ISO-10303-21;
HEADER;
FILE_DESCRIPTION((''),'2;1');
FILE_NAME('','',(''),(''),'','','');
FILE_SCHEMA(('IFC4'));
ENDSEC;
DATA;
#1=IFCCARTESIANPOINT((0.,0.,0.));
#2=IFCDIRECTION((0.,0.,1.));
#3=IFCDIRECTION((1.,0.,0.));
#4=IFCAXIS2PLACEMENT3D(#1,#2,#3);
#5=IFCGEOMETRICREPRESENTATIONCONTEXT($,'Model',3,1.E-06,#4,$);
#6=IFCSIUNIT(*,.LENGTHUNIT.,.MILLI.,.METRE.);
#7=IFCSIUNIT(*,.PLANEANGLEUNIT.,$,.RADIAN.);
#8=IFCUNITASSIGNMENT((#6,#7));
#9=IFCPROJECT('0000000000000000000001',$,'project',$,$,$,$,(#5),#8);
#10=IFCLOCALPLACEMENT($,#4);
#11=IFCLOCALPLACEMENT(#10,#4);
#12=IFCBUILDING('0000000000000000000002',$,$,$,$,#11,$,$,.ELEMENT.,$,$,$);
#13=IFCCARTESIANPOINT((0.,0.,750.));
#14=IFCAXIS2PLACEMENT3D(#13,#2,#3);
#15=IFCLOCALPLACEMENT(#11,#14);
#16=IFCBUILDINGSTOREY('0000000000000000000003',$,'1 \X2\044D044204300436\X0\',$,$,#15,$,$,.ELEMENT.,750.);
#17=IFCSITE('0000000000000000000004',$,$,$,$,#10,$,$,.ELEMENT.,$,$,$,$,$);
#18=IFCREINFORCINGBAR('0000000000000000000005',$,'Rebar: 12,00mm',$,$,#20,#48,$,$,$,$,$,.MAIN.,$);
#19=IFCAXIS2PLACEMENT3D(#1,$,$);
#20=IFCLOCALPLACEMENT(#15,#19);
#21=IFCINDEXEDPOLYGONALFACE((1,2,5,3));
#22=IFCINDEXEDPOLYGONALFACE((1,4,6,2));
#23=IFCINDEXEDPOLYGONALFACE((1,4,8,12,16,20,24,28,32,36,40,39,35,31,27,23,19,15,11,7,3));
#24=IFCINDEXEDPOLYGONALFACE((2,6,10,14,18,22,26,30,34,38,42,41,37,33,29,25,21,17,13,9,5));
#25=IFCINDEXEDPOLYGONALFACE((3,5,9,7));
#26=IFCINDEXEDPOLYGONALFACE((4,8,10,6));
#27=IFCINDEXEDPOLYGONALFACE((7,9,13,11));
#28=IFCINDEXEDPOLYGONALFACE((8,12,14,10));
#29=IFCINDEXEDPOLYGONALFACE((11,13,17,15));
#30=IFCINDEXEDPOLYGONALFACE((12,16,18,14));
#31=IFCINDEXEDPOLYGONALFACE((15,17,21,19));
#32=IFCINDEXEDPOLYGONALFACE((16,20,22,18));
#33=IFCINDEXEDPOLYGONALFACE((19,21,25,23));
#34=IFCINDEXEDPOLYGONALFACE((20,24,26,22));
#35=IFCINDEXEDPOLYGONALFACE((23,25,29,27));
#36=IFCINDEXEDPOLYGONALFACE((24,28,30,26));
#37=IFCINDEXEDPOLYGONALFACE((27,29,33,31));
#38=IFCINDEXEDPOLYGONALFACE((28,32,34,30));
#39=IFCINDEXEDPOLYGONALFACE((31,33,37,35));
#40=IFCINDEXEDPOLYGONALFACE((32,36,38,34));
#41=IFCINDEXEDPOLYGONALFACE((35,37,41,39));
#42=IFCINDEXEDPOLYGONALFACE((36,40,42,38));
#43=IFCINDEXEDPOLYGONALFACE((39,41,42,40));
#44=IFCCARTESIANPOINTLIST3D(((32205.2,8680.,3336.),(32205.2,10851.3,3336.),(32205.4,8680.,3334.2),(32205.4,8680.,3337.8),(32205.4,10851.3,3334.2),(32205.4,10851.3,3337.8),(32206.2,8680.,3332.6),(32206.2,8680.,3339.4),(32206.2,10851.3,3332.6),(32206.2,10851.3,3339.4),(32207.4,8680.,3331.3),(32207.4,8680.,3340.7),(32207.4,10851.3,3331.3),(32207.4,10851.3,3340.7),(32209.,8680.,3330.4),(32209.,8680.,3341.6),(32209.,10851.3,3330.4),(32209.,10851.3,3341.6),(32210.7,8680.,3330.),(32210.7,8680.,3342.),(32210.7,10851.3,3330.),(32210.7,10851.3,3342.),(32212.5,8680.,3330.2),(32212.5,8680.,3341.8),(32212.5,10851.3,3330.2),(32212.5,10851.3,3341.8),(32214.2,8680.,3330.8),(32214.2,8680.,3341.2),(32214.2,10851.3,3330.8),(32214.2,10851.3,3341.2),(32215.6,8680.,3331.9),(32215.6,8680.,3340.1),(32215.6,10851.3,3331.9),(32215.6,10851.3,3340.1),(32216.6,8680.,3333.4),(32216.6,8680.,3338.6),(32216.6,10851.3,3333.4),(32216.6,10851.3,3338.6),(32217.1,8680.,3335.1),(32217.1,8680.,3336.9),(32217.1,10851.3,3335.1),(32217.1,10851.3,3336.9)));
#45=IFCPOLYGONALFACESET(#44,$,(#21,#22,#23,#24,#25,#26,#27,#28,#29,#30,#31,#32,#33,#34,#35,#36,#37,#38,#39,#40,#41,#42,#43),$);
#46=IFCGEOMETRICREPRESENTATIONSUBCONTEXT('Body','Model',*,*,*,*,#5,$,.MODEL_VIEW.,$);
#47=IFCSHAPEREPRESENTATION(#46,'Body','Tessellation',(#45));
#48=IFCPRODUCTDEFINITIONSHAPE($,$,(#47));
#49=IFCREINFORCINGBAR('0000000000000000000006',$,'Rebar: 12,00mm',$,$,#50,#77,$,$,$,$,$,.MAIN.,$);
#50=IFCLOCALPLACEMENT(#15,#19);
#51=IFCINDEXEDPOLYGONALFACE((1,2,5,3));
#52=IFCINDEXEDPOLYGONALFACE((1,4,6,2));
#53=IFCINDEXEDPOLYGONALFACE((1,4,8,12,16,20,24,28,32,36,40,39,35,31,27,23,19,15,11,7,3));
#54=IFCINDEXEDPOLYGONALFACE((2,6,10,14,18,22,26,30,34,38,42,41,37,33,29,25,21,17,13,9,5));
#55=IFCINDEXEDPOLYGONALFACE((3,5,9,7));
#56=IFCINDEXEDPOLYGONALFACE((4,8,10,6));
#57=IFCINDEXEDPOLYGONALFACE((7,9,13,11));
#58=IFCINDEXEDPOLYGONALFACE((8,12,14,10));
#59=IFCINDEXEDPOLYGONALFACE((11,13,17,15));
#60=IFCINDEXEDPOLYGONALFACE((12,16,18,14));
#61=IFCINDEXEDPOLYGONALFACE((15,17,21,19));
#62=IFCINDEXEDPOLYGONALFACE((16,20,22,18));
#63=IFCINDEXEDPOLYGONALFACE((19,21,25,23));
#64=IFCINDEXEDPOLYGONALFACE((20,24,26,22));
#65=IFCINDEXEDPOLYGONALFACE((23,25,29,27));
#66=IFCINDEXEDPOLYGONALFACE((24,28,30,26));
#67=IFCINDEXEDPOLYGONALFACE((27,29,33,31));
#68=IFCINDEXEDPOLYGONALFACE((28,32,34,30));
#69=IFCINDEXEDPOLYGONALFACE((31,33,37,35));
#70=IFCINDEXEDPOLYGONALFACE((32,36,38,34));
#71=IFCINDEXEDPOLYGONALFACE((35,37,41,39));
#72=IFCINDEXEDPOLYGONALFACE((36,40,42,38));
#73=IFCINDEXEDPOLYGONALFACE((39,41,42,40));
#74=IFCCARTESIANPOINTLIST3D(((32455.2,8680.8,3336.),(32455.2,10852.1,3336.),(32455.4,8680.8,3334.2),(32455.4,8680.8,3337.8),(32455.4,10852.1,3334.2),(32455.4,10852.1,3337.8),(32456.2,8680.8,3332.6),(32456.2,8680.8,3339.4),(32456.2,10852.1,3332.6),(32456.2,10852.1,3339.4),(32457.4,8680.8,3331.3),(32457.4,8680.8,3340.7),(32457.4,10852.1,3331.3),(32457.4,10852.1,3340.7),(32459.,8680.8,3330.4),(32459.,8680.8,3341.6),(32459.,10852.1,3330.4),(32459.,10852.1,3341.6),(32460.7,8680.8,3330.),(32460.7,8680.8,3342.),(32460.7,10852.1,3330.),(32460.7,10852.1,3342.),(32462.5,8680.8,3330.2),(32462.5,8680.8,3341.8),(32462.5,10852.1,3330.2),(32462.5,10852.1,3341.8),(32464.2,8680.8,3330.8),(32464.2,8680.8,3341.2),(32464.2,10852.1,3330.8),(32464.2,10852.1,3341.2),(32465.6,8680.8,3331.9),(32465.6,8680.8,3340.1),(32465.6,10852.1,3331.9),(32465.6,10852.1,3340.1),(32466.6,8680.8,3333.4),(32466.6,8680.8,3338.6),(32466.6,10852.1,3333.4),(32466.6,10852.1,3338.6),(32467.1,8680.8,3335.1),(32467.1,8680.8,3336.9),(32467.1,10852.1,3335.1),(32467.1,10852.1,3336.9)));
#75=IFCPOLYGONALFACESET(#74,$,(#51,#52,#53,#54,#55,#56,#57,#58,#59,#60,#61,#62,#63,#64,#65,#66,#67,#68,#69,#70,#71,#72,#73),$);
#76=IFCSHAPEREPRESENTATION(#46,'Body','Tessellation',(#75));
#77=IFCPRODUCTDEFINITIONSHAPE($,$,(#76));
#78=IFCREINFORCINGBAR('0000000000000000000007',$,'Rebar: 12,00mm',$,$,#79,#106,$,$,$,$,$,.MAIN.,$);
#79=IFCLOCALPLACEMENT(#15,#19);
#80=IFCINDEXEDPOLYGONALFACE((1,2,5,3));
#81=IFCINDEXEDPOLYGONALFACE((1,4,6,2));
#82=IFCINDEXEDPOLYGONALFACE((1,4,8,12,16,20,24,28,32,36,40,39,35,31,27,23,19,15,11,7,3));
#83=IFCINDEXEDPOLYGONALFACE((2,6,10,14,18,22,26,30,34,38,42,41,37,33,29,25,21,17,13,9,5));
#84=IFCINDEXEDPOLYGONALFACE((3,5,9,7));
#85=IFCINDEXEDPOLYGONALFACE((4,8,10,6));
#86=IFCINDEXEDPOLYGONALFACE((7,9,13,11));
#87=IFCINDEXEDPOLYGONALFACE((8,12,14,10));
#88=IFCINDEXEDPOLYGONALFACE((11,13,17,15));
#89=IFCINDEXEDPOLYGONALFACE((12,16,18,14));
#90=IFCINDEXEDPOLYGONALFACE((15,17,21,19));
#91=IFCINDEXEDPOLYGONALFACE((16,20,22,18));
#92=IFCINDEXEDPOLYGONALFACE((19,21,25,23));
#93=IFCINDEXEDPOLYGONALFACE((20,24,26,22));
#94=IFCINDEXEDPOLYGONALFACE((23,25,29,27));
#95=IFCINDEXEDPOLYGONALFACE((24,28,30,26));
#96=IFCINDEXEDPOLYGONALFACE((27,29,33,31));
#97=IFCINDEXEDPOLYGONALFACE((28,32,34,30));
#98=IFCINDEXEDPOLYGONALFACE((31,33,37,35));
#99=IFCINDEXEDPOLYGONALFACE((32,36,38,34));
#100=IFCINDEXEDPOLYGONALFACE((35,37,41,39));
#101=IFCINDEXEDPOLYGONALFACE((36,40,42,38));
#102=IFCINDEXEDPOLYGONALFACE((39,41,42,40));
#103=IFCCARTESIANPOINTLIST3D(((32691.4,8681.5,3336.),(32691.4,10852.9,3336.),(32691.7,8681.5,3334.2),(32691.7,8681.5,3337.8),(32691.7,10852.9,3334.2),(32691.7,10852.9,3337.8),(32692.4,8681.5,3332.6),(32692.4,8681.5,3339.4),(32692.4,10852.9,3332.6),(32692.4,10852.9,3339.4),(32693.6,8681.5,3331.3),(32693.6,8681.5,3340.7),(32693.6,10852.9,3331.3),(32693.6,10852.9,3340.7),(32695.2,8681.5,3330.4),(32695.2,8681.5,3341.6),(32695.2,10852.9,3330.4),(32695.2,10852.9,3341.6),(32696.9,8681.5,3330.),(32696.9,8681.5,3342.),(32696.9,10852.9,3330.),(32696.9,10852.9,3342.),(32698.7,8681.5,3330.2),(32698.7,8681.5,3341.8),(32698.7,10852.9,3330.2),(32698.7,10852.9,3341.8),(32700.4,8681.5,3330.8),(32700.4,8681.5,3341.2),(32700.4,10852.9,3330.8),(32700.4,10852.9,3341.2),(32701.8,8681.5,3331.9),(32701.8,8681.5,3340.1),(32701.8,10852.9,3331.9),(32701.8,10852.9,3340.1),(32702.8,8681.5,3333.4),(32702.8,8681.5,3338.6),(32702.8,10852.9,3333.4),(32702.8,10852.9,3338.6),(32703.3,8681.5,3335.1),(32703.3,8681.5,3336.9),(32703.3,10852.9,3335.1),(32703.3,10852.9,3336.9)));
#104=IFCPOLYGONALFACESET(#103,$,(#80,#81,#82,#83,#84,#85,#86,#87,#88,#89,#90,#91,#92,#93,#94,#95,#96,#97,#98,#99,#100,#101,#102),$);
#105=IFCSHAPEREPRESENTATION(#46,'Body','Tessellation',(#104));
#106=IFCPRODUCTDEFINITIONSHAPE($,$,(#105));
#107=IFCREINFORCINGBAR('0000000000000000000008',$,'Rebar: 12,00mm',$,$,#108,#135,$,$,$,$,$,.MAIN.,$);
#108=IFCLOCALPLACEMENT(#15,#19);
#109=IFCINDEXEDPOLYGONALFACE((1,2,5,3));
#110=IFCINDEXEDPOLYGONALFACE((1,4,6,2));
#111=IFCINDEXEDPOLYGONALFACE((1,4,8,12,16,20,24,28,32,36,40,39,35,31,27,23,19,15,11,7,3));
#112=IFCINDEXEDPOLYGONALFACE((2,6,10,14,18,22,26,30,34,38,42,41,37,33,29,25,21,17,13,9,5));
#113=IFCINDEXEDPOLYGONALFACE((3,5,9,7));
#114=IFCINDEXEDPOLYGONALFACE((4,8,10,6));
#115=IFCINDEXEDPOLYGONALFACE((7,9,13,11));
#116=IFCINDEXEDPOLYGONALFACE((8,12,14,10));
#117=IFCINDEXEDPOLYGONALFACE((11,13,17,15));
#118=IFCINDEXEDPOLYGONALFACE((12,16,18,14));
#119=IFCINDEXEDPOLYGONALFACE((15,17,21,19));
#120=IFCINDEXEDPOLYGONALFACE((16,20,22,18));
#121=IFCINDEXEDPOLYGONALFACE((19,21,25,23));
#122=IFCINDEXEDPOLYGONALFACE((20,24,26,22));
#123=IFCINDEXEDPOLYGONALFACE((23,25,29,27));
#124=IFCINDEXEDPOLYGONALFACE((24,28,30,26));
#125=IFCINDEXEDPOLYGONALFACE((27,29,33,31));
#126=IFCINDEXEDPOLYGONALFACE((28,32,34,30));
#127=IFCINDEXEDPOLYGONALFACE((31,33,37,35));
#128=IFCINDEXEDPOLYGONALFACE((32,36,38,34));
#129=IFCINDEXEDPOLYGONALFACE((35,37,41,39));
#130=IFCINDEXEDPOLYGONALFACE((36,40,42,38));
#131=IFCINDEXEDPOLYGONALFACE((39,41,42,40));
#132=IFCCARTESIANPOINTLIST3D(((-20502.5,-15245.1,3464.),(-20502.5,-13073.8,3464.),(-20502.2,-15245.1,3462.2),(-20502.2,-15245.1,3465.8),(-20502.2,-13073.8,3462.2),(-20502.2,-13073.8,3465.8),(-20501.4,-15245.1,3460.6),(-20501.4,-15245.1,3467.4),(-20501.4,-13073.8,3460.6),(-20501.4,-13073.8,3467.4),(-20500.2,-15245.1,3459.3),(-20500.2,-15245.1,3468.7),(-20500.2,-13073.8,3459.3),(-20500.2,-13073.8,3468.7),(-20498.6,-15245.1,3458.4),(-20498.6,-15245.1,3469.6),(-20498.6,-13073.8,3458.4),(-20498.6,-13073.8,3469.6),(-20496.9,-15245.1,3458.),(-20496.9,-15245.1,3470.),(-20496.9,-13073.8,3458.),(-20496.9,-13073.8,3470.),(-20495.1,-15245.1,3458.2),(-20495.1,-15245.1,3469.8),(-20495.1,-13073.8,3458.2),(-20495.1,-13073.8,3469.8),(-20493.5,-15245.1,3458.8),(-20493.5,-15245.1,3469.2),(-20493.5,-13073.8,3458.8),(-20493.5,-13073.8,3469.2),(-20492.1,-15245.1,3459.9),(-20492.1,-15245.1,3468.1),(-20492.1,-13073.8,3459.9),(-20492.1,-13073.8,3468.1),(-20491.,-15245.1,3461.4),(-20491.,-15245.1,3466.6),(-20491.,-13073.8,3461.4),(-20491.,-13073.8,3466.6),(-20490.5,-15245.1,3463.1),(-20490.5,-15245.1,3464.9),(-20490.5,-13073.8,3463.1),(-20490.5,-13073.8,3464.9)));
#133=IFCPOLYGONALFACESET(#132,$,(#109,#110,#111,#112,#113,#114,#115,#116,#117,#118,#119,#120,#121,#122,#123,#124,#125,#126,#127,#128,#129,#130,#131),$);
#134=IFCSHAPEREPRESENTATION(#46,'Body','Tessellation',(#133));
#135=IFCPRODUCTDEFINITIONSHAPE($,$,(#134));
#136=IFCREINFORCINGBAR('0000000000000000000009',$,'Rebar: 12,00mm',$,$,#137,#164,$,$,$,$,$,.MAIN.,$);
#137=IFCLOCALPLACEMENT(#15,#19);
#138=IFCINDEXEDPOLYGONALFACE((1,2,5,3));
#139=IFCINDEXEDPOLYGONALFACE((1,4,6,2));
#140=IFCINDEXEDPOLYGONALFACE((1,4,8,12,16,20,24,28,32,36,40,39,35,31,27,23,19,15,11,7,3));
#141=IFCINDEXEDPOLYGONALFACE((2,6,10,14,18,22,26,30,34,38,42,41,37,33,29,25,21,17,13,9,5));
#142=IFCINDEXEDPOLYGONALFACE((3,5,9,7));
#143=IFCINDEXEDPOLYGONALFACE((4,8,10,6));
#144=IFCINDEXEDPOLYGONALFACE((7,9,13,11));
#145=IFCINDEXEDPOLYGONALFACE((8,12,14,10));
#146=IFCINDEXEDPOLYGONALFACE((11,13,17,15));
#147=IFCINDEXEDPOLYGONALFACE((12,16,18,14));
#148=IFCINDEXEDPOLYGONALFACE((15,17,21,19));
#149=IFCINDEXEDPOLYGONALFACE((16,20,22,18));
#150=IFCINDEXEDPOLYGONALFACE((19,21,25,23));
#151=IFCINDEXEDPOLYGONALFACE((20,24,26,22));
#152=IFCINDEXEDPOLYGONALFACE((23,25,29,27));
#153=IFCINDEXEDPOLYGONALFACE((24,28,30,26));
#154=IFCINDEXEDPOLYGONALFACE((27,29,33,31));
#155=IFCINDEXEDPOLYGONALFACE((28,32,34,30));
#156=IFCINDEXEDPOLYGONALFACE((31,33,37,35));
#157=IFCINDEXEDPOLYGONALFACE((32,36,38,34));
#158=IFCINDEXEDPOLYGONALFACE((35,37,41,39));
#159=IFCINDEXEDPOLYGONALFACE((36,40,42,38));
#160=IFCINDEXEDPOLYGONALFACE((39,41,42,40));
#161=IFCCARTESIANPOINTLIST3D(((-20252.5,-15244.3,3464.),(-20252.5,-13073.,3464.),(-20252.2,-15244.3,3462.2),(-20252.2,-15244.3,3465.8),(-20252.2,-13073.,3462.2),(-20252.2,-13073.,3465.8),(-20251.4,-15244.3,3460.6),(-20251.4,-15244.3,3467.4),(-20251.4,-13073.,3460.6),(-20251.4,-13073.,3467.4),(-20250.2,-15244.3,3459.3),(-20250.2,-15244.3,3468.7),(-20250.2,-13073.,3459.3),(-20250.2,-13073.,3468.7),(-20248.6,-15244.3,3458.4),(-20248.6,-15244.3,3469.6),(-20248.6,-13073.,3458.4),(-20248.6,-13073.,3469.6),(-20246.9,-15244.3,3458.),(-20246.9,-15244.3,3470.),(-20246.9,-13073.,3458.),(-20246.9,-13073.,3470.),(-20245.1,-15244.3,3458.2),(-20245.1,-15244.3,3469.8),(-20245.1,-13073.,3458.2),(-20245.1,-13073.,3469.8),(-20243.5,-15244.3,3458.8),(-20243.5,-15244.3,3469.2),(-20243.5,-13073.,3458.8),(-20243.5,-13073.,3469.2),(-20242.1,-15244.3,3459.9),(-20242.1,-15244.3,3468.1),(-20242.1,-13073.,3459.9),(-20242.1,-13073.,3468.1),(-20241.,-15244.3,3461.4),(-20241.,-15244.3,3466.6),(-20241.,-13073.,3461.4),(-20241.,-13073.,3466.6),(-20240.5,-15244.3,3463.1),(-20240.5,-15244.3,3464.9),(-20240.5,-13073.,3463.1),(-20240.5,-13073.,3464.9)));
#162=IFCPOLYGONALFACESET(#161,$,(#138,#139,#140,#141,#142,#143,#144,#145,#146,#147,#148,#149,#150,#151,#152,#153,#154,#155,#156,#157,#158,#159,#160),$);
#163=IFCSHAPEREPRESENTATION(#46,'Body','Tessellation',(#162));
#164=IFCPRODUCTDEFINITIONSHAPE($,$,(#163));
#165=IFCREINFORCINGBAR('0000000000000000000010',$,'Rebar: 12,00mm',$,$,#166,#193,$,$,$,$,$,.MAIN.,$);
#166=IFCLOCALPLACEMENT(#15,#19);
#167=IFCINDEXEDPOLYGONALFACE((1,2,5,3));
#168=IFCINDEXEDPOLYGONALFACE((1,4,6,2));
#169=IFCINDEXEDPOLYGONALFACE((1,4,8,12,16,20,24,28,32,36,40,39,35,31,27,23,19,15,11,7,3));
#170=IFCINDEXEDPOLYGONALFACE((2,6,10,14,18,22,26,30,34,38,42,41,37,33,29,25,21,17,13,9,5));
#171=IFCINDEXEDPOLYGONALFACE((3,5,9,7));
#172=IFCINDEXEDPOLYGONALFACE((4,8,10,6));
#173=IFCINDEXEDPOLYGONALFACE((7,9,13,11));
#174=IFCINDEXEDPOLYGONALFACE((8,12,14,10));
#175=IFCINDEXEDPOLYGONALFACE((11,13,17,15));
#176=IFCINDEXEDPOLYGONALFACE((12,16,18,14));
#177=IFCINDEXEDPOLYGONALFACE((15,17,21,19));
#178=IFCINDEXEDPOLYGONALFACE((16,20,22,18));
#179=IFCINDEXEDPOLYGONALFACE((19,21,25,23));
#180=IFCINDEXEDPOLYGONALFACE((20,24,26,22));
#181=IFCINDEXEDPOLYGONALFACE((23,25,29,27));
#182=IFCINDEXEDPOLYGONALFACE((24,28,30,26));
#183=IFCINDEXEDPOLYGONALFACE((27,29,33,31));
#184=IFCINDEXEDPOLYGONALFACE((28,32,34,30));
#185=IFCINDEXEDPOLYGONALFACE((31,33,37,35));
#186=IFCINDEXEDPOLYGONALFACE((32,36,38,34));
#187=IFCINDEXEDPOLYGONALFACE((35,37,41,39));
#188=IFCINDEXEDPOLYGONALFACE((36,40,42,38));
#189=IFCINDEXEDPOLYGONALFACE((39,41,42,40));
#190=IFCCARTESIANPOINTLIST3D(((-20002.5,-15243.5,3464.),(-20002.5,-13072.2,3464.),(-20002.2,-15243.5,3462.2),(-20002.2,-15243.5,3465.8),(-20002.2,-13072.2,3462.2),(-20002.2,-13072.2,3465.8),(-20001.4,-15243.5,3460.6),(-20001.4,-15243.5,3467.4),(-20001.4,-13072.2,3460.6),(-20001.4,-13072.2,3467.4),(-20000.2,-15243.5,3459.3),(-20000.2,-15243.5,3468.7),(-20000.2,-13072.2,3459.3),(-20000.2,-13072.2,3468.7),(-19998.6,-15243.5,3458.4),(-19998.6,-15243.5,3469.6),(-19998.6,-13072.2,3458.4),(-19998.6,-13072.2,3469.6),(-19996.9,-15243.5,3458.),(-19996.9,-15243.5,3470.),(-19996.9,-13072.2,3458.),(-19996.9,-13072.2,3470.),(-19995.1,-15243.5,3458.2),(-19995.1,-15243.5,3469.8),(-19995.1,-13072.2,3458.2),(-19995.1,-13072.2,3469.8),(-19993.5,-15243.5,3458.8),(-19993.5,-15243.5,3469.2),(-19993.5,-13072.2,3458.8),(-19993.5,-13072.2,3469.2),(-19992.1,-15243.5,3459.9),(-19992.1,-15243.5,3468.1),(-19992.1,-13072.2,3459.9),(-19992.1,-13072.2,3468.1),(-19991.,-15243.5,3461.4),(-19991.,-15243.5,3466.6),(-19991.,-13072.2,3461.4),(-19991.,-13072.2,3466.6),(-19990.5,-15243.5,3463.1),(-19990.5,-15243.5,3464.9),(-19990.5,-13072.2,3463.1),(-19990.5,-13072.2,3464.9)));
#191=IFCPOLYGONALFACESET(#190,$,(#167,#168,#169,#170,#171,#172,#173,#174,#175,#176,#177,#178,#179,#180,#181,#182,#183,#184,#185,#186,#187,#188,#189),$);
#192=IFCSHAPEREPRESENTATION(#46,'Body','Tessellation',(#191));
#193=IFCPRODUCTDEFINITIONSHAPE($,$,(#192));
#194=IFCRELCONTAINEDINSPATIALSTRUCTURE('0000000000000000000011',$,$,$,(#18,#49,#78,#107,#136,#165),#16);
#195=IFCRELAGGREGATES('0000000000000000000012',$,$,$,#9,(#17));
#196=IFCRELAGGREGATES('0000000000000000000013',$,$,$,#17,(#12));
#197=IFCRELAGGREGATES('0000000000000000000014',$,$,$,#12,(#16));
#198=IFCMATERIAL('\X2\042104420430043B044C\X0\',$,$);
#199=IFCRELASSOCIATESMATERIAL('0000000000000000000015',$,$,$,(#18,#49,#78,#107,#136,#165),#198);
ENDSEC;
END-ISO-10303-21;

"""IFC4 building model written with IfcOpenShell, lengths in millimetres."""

from ifc_helpers import new_model, entity, si_unit, frame, origin_with_axes, place, context, subcontext, project, spatial, source, transform, mapped, material, element, save


model = new_model("IFC4")

# Units and contexts
model_context = context("Model", 3, precision=1e-06, world=origin_with_axes())
body_context = subcontext(model_context, "Body", "Model", "MODEL_VIEW")
ifc_project = project(units=[si_unit("LENGTHUNIT", "METRE", prefix="MILLI"), si_unit("PLANEANGLEUNIT", "RADIAN")], contexts=[model_context])

# Site, building, storey
site_placement = place(None, origin_with_axes())
site = spatial("IfcSite", under=ifc_project, at=site_placement, CompositionType="ELEMENT")
building_placement = place(site_placement, origin_with_axes())
building = spatial("IfcBuilding", under=site, at=building_placement, CompositionType="ELEMENT")
storey_placement = place(building_placement, frame((0.0, 0.0, 750.0), z_axis=(0.0, 0.0, 1.0), x_axis=(1.0, 0.0, 0.0)))
storey = spatial("IfcBuildingStorey", under=building, at=storey_placement, Name="1 этаж", CompositionType="ELEMENT", Elevation=750.0)

# Reinforcing bars
ifc_material = material(Name="Сталь")
shared_shape_1 = source(origin_with_axes(), body_context, "Body", "AdvancedSweptSolid", [
    entity("IfcSweptDiskSolid", entity("IfcIndexedPolyCurve", entity("IfcCartesianPointList3D", [[0.0, 0.0, 0.0], [2171.3, 0.0, 0.0]]), [entity("IfcLineIndex", [1, 2])]), 6.0),
])
reinforcing_bar_1_placement = place(storey_placement, origin_with_axes())
element("IfcReinforcingBar", 1, at=reinforcing_bar_1_placement, inside=storey, material=ifc_material, Name="Rebar: 12,00mm", PredefinedType="MAIN", context=body_context, shape_type="MappedRepresentation", body=[
    mapped(shared_shape_1, transform((32211.2, 8680.0, 3336.0), x_axis=(0.0, 1.0, 0.0), y_axis=(-1.0, 0.0, 0.0), z_axis=(0.0, 0.0, 1.0), scale=1.0)),
])
reinforcing_bar_2_placement = place(storey_placement, origin_with_axes())
element("IfcReinforcingBar", 2, at=reinforcing_bar_2_placement, inside=storey, material=ifc_material, Name="Rebar: 12,00mm", PredefinedType="MAIN", context=body_context, shape_type="MappedRepresentation", body=[
    mapped(shared_shape_1, transform((32461.2, 8680.8, 3336.0), x_axis=(0.0, 1.0, 0.0), y_axis=(-1.0, 0.0, 0.0), z_axis=(0.0, 0.0, 1.0), scale=1.0)),
])
reinforcing_bar_3_placement = place(storey_placement, origin_with_axes())
element("IfcReinforcingBar", 3, at=reinforcing_bar_3_placement, inside=storey, material=ifc_material, Name="Rebar: 12,00mm", PredefinedType="MAIN", context=body_context, shape_type="MappedRepresentation", body=[
    mapped(shared_shape_1, transform((32697.4, 8681.5, 3336.0), x_axis=(0.0, 1.0, 0.0), y_axis=(-1.0, 0.0, 0.0), z_axis=(0.0, 0.0, 1.0), scale=1.0)),
])
reinforcing_bar_4_placement = place(storey_placement, origin_with_axes())
element("IfcReinforcingBar", 4, at=reinforcing_bar_4_placement, inside=storey, material=ifc_material, Name="Rebar: 12,00mm", PredefinedType="MAIN", context=body_context, shape_type="MappedRepresentation", body=[
    mapped(shared_shape_1, transform((-20496.5, -15245.1, 3464.0), x_axis=(0.0, 1.0, 0.0), y_axis=(-1.0, 0.0, 0.0), z_axis=(0.0, 0.0, 1.0), scale=1.0)),
])
reinforcing_bar_5_placement = place(storey_placement, origin_with_axes())
element("IfcReinforcingBar", 5, at=reinforcing_bar_5_placement, inside=storey, material=ifc_material, Name="Rebar: 12,00mm", PredefinedType="MAIN", context=body_context, shape_type="MappedRepresentation", body=[
    mapped(shared_shape_1, transform((-20246.5, -15244.3, 3464.0), x_axis=(0.0, 1.0, 0.0), y_axis=(-1.0, 0.0, 0.0), z_axis=(0.0, 0.0, 1.0), scale=1.0)),
])
reinforcing_bar_6_placement = place(storey_placement, origin_with_axes())
element("IfcReinforcingBar", 6, at=reinforcing_bar_6_placement, inside=storey, material=ifc_material, Name="Rebar: 12,00mm", PredefinedType="MAIN", context=body_context, shape_type="MappedRepresentation", body=[
    mapped(shared_shape_1, transform((-19996.5, -15243.5, 3464.0), x_axis=(0.0, 1.0, 0.0), y_axis=(-1.0, 0.0, 0.0), z_axis=(0.0, 0.0, 1.0), scale=1.0)),
])

save(model, "model.ifc")
